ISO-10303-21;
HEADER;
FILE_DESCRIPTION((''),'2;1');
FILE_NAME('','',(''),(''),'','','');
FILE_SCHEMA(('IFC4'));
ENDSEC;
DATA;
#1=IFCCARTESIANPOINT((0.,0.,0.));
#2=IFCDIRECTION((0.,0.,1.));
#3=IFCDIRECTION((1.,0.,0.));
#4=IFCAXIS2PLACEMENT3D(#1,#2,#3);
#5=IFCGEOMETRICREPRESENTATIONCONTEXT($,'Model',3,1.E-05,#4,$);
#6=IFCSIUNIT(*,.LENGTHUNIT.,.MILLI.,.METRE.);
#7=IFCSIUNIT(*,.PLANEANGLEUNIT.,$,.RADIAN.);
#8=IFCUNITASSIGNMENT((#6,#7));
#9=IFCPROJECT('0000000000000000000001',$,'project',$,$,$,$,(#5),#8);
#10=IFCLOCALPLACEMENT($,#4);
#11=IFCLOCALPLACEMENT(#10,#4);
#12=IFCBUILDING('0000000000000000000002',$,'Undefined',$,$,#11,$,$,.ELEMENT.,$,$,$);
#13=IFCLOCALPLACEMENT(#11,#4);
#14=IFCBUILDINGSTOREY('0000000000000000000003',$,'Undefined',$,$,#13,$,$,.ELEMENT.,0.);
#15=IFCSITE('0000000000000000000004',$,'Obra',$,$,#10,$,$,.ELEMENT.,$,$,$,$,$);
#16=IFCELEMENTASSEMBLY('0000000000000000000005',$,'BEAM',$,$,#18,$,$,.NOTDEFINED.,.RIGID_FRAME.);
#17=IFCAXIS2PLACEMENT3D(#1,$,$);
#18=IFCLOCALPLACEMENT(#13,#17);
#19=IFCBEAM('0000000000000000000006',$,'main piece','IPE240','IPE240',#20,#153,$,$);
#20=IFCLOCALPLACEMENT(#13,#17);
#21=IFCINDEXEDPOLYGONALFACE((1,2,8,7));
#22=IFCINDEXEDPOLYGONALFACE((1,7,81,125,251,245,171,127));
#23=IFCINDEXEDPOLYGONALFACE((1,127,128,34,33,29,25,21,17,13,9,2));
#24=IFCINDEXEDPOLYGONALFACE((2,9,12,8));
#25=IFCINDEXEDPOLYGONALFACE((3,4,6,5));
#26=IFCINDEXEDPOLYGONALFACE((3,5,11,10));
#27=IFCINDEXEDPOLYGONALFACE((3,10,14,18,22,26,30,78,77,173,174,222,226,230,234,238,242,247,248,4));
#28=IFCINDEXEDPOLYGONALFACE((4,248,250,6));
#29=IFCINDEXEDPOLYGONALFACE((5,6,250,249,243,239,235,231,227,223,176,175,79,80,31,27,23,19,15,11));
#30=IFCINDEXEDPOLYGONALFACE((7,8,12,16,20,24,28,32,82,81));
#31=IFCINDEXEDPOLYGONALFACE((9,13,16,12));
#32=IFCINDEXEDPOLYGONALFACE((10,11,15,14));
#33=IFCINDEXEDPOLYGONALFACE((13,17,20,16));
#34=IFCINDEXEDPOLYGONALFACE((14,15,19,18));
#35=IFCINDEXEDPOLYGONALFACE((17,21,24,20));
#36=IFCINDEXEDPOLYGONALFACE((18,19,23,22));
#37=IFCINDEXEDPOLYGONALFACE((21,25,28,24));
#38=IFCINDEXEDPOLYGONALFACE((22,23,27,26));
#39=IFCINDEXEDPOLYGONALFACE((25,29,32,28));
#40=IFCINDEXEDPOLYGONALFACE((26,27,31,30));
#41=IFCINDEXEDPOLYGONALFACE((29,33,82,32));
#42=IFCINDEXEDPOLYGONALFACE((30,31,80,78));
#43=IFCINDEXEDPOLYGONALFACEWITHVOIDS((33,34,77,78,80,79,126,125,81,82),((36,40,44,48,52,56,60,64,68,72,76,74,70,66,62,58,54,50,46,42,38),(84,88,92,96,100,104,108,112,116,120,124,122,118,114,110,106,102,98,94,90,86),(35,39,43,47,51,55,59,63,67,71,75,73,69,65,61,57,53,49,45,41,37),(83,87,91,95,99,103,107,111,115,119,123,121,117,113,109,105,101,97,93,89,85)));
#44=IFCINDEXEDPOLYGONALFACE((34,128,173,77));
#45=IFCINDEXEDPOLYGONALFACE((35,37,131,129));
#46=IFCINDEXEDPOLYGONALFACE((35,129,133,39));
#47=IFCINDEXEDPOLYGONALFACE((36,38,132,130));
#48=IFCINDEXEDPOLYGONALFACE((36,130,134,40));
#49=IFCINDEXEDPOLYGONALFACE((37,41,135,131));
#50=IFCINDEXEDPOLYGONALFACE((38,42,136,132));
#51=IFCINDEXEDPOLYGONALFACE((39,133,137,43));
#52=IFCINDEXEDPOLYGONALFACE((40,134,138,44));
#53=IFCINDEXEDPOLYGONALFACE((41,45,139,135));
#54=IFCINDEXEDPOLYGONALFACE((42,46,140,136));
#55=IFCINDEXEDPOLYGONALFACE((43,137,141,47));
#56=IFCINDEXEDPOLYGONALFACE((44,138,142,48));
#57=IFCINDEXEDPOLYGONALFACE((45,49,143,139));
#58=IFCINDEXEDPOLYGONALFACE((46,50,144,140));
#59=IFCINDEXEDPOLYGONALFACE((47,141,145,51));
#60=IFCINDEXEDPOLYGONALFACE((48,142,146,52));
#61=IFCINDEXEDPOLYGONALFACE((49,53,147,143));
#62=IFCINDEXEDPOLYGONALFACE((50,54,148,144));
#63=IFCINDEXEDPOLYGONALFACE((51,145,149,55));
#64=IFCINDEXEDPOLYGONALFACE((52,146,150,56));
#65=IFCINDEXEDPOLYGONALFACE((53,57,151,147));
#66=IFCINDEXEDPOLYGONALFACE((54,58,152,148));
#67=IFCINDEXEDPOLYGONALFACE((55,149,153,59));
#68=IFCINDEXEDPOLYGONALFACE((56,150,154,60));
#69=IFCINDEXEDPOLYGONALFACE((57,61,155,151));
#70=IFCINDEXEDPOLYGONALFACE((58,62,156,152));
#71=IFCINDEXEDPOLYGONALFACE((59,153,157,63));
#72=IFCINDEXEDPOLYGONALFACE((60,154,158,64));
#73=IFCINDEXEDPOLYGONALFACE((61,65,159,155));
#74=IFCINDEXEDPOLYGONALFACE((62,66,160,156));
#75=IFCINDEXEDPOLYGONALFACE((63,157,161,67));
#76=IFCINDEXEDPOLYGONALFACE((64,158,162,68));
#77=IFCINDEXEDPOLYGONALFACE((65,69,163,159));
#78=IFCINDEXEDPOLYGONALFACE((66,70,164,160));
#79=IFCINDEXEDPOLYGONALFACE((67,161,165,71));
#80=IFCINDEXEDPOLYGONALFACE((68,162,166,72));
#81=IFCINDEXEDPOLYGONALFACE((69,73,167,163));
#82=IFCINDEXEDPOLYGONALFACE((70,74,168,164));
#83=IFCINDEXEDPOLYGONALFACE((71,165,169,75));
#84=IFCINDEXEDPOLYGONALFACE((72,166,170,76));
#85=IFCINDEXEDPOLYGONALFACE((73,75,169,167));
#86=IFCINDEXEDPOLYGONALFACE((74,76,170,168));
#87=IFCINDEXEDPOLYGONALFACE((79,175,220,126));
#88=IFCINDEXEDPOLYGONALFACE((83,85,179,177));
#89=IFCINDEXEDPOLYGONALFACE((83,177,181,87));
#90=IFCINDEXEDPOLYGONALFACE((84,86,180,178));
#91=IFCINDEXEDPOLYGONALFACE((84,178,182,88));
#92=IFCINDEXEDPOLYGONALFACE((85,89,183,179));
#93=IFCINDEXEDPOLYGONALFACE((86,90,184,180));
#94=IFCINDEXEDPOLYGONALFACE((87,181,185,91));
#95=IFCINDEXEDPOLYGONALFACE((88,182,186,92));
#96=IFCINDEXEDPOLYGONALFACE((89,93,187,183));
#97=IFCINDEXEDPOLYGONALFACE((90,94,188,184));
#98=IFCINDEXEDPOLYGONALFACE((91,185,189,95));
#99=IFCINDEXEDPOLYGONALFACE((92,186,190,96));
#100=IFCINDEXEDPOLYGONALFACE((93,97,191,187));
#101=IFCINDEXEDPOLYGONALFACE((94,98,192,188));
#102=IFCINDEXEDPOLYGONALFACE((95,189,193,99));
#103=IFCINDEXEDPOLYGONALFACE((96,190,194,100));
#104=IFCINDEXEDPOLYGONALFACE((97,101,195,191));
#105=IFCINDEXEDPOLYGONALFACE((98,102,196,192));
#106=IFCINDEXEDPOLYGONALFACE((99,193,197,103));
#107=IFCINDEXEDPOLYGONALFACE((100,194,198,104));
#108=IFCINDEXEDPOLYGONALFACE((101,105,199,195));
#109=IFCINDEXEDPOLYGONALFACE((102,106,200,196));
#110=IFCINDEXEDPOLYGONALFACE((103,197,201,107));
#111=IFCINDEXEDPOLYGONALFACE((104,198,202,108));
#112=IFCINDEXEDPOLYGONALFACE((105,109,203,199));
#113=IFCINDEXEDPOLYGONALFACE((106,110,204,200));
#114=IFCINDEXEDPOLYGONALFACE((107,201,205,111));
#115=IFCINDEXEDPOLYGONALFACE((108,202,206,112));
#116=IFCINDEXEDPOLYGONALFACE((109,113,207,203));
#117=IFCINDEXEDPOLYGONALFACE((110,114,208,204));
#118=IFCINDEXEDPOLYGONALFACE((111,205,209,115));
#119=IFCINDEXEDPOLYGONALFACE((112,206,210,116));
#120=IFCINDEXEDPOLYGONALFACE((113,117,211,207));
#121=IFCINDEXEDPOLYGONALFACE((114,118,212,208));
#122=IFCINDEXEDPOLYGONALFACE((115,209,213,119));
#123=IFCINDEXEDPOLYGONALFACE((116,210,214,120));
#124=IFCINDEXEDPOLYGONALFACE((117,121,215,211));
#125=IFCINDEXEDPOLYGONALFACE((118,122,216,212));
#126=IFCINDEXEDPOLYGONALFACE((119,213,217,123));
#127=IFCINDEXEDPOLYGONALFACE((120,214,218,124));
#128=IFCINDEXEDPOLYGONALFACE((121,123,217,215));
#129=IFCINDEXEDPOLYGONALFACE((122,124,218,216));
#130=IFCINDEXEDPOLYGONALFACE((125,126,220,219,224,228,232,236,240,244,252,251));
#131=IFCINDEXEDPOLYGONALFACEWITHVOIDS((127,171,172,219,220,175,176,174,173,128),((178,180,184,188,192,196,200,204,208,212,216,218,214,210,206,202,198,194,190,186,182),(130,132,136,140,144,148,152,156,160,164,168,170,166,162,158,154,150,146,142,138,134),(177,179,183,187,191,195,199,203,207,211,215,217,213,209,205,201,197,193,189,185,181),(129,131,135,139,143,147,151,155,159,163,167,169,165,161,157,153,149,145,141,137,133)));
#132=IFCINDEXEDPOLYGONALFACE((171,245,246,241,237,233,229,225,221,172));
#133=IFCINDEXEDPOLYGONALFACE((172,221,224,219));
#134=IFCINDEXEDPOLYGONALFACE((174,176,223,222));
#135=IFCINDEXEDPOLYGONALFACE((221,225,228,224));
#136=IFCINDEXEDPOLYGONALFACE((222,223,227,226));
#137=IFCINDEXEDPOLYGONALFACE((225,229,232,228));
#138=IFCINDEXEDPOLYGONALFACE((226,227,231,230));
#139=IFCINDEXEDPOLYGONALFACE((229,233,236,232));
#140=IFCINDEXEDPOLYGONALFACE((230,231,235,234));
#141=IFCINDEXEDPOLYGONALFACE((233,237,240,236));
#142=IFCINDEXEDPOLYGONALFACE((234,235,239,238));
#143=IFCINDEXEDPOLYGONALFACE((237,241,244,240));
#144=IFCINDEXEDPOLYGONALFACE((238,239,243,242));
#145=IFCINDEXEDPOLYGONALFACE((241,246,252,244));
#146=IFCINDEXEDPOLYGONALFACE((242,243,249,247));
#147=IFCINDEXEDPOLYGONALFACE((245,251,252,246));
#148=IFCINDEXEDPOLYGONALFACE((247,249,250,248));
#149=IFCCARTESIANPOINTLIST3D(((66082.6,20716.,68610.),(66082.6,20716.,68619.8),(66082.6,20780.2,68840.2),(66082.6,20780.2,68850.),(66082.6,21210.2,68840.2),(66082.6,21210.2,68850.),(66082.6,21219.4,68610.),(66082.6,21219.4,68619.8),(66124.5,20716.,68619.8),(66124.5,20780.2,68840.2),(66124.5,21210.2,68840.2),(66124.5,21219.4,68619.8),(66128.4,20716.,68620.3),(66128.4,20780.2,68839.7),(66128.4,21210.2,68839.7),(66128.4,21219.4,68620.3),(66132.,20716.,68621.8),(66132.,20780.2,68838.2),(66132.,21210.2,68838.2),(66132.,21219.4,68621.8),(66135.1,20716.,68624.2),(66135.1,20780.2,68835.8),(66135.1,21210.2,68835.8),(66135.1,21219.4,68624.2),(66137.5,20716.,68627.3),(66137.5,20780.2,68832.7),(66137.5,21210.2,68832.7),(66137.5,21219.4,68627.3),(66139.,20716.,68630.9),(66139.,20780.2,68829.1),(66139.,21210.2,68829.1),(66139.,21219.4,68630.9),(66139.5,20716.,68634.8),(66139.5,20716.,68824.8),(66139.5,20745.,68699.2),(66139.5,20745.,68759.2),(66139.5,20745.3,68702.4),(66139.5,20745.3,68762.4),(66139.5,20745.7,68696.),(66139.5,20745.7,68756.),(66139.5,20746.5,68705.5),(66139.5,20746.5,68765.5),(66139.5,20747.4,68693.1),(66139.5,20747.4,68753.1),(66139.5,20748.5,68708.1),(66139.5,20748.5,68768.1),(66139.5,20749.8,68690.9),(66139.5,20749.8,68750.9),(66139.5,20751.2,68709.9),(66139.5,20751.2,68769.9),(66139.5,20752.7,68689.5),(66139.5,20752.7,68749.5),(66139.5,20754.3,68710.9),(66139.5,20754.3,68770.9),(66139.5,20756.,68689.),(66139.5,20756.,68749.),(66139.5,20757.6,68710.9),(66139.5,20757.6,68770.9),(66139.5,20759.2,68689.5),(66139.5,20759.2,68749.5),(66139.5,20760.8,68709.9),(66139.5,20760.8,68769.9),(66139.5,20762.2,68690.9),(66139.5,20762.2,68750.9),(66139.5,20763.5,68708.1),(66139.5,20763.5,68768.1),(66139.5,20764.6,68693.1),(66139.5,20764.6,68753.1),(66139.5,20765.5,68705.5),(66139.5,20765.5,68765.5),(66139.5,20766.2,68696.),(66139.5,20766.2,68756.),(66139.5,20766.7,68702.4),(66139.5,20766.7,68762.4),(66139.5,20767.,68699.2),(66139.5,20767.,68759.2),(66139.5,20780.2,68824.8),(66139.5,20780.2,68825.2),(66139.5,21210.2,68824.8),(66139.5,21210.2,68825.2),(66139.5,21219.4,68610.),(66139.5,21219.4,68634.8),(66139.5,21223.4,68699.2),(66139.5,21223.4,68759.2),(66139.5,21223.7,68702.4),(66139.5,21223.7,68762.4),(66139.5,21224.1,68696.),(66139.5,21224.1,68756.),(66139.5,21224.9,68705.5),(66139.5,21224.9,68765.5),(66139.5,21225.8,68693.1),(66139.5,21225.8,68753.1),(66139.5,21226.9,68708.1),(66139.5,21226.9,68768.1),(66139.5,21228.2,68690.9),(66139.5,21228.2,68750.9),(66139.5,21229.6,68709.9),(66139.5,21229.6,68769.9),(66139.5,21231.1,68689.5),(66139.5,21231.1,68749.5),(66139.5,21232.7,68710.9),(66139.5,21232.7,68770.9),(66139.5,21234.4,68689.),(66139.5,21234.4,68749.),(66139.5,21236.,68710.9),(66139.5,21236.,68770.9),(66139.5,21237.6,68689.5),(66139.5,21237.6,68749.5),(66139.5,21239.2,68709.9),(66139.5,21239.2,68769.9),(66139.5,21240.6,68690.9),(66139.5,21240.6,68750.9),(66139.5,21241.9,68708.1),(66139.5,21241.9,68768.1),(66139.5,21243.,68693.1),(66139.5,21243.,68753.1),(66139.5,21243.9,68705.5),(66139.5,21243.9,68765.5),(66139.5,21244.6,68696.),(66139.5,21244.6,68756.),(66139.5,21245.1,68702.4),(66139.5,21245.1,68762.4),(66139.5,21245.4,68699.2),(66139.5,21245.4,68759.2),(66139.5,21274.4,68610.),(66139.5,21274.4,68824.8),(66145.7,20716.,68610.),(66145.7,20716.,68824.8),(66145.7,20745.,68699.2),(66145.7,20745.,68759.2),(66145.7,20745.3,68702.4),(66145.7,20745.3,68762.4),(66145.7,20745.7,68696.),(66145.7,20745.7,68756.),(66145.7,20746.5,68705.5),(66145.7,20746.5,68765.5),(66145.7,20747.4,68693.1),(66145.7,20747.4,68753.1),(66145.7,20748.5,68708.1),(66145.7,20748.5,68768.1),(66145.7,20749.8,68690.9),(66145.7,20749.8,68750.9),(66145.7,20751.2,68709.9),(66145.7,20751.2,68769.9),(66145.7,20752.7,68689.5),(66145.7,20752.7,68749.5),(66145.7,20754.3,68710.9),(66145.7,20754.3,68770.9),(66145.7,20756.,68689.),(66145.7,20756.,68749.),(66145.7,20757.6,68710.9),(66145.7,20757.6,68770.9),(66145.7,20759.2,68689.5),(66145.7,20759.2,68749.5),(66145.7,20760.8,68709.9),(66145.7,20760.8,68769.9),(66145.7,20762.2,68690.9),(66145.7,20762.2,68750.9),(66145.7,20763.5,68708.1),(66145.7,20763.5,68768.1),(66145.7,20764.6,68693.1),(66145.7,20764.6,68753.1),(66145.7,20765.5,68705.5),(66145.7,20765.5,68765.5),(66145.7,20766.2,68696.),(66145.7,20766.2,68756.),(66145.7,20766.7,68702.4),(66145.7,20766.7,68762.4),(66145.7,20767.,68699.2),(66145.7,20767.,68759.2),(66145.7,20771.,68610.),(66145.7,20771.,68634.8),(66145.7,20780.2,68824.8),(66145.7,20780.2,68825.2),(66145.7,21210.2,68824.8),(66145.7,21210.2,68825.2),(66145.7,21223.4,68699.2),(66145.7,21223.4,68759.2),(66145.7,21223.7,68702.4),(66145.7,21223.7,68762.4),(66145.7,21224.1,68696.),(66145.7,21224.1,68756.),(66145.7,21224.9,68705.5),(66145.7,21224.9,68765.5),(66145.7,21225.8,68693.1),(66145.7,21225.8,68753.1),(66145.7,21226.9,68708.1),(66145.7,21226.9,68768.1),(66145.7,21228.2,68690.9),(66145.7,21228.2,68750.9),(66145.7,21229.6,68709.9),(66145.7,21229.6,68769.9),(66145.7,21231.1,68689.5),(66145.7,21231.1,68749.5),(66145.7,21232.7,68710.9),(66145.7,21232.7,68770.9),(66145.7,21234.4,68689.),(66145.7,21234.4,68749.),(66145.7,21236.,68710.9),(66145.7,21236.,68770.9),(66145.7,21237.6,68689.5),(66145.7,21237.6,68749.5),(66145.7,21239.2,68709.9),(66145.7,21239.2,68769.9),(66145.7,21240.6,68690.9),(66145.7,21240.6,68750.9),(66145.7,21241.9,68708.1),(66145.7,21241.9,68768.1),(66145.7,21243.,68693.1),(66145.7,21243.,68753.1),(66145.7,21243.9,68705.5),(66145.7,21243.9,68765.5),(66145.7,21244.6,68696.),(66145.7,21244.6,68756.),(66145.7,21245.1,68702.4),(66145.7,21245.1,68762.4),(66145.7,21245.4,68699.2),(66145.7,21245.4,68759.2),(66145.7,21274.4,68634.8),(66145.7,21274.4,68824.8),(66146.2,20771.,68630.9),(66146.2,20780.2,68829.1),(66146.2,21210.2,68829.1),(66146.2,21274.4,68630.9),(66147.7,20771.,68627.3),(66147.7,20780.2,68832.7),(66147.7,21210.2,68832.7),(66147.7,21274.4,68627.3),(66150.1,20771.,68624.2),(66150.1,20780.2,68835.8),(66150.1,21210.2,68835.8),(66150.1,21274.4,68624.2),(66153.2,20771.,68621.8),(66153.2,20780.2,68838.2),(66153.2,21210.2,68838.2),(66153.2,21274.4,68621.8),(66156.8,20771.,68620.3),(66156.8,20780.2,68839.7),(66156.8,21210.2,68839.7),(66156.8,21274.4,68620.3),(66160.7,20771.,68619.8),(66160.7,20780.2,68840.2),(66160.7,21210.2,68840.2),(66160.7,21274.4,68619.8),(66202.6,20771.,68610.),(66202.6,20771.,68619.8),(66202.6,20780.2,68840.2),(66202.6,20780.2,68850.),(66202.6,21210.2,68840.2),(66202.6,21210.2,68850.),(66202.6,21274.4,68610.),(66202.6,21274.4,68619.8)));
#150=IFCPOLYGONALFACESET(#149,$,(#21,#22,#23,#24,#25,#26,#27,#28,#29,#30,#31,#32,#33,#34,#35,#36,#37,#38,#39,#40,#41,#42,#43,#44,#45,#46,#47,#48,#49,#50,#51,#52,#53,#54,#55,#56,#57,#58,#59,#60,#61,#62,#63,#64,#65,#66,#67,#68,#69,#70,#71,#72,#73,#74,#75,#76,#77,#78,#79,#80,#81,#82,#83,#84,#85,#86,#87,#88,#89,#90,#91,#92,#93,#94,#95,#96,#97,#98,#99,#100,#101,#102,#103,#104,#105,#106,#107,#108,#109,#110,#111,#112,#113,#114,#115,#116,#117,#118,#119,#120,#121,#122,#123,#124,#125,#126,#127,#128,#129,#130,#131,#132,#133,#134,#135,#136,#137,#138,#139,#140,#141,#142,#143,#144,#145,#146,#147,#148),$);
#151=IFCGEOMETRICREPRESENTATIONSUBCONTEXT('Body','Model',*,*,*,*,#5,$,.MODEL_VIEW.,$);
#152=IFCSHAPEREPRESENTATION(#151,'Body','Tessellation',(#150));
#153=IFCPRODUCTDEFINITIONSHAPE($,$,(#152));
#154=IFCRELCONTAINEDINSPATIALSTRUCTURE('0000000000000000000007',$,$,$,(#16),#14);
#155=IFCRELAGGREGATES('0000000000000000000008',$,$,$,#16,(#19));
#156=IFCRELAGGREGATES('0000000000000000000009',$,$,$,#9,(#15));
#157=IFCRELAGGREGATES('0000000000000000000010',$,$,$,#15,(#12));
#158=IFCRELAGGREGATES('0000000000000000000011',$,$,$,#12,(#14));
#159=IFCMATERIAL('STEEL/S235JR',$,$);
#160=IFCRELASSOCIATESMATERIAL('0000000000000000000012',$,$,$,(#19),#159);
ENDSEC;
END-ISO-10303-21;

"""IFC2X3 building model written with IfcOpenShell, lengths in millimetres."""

from ifc_helpers import new_model, si_unit, frame, origin_with_axes, origin_2d_with_axis, place, context, subcontext, project, spatial, rectangle, circle, i_section, extrude, clip, halfspace, source, transform, mapped, material, element, aggregate, save


model = new_model("IFC2X3")

# Units and contexts
model_context = context("Model", 3, precision=1e-05, world=origin_with_axes())
body_context = subcontext(model_context, "Body", "Model", "MODEL_VIEW")
ifc_project = project(units=[si_unit("LENGTHUNIT", "METRE", prefix="MILLI"), si_unit("PLANEANGLEUNIT", "RADIAN")], contexts=[model_context])

# Site, building, storey
site_placement = place(None, origin_with_axes())
site = spatial("IfcSite", under=ifc_project, at=site_placement, Name="Obra", CompositionType="ELEMENT")
building_placement = place(site_placement, origin_with_axes())
building = spatial("IfcBuilding", under=site, at=building_placement, Name="Undefined", CompositionType="ELEMENT")
storey_placement = place(building_placement, origin_with_axes())
storey = spatial("IfcBuildingStorey", under=building, at=storey_placement, Name="Undefined", CompositionType="ELEMENT", Elevation=0.0)

# Shared definitions
ifc_material_1 = material(Name="STEEL/S235JR")

# Element assembly, beam, openings
assembly_1_placement = place(storey_placement, origin_with_axes())
assembly_1 = element("IfcElementAssembly", 1, at=assembly_1_placement, inside=storey, Name="BEAM", AssemblyPlace="NOTDEFINED", PredefinedType="RIGID_FRAME")
beam_1_placement = place(assembly_1_placement, frame((66142.6, 20782.9, 68730.0), z_axis=(0.0, 0.0, 1.0), x_axis=(0.0, 1.0, 0.0)))
beam_1 = element("IfcBeam", 2, at=beam_1_placement, material=ifc_material_1, Name="main piece", Description="IPE240", ObjectType="IPE240", context=body_context, shape_type="Clipping", body=[
    clip(clip(extrude(i_section(OverallWidth=120.0, OverallDepth=240.0, WebThickness=6.2, FlangeThickness=9.8, FilletRadius=15.0, at=origin_2d_with_axis()), frame((491.4, 0.0, 0.0), z_axis=(-1.0, 0.0, 0.0), x_axis=(0.0, -1.0, 0.0)), (0.0, 0.0, 1.0), 558.4), halfspace(frame((491.4, 0.0, -220.0), z_axis=(-1.0, -0.000002, 0.0), x_axis=(-0.000002, 1.0, 0.0)), True)), halfspace(frame((-66.9, 0.0, -220.0), z_axis=(1.0, 0.000001, 0.0), x_axis=(0.000002, -1.0, 0.0)), True)),
])
opening_1_placement = place(assembly_1_placement, frame((66142.6, 20782.9, 68730.0), z_axis=(0.0, 0.0, 1.0), x_axis=(0.0, 1.0, 0.0)))
element("IfcOpeningElement", 3, at=opening_1_placement, cuts=beam_1, ObjectType="Recess", context=body_context, shape_type="SweptSolid", body=[
    extrude(rectangle(XDim=65.0, YDim=300.0, at=origin_2d_with_axis()), frame((-44.4, -153.1, 109.8), z_axis=(0.0, 0.0, -1.0), x_axis=(1.0, 0.000001, 0.0)), (0.0, 0.0, 1.0), 249.6),
])
opening_2_placement = place(assembly_1_placement, frame((66142.6, 20782.9, 68730.0), z_axis=(0.0, 0.0, 1.0), x_axis=(0.0, 1.0, 0.0)))
element("IfcOpeningElement", 4, at=opening_2_placement, cuts=beam_1, ObjectType="Recess", context=body_context, shape_type="SweptSolid", body=[
    extrude(rectangle(XDim=26.2, YDim=76.2, at=origin_2d_with_axis()), frame((-40.8, -61.0, 107.9), z_axis=(-0.000002, 1.0, 0.0), x_axis=(0.0, 0.0, -1.0)), (0.0, 0.0, 1.0), 122.0),
])
opening_3_placement = place(assembly_1_placement, frame((66142.6, 20782.9, 68730.0), z_axis=(0.0, 0.0, 1.0), x_axis=(0.0, 1.0, 0.0)))
element("IfcOpeningElement", 5, at=opening_3_placement, cuts=beam_1, ObjectType="Recess", context=body_context, shape_type="SweptSolid", body=[
    extrude(rectangle(XDim=65.0, YDim=300.0, at=origin_2d_with_axis()), frame((468.9, 153.1, 109.8), z_axis=(0.0, 0.0, -1.0), x_axis=(-1.0, -0.000002, 0.0)), (0.0, 0.0, 1.0), 249.6),
])
opening_4_placement = place(assembly_1_placement, frame((66142.6, 20782.9, 68730.0), z_axis=(0.0, 0.0, 1.0), x_axis=(0.0, 1.0, 0.0)))
element("IfcOpeningElement", 6, at=opening_4_placement, cuts=beam_1, ObjectType="Recess", context=body_context, shape_type="SweptSolid", body=[
    extrude(rectangle(XDim=26.2, YDim=76.2, at=origin_2d_with_axis()), frame((465.3, 61.0, 107.9), z_axis=(0.000002, -1.0, 0.0), x_axis=(0.0, 0.0, -1.0)), (0.0, 0.0, 1.0), 122.0),
])
shared_shape_1 = source(origin_with_axes(), body_context, "Body", "SweptSolid", [
    extrude(circle(Radius=11.0, at=origin_2d_with_axis()), frame((0.0, -3.2, 0.0), z_axis=(0.0, 1.0, 0.0), x_axis=(1.0, 0.0, 0.0)), (0.0, 0.0, 1.0), 6.4),
])
opening_5_placement = place(assembly_1_placement, frame((66142.6, 20716.0, 68850.0), z_axis=(-0.000002, 1.0, 0.0), x_axis=(0.0, 0.0, -1.0)))
element("IfcOpeningElement", 7, at=opening_5_placement, cuts=beam_1, ObjectType="Opening", context=body_context, shape_type="MappedRepresentation", body=[
    mapped(shared_shape_1, transform((90.0, 0.0, 40.0))),
    mapped(shared_shape_1, transform((150.0, 0.0, 40.0))),
])
opening_6_placement = place(assembly_1_placement, frame((66142.6, 21274.4, 68850.0), z_axis=(0.000002, -1.0, 0.0), x_axis=(0.0, 0.0, -1.0)))
element("IfcOpeningElement", 8, at=opening_6_placement, cuts=beam_1, ObjectType="Opening", context=body_context, shape_type="MappedRepresentation", body=[
    mapped(shared_shape_1, transform((90.0, 0.0, 40.0))),
    mapped(shared_shape_1, transform((150.0, 0.0, 40.0))),
])
aggregate(assembly_1, [beam_1])

save(model, "model.ifc")
